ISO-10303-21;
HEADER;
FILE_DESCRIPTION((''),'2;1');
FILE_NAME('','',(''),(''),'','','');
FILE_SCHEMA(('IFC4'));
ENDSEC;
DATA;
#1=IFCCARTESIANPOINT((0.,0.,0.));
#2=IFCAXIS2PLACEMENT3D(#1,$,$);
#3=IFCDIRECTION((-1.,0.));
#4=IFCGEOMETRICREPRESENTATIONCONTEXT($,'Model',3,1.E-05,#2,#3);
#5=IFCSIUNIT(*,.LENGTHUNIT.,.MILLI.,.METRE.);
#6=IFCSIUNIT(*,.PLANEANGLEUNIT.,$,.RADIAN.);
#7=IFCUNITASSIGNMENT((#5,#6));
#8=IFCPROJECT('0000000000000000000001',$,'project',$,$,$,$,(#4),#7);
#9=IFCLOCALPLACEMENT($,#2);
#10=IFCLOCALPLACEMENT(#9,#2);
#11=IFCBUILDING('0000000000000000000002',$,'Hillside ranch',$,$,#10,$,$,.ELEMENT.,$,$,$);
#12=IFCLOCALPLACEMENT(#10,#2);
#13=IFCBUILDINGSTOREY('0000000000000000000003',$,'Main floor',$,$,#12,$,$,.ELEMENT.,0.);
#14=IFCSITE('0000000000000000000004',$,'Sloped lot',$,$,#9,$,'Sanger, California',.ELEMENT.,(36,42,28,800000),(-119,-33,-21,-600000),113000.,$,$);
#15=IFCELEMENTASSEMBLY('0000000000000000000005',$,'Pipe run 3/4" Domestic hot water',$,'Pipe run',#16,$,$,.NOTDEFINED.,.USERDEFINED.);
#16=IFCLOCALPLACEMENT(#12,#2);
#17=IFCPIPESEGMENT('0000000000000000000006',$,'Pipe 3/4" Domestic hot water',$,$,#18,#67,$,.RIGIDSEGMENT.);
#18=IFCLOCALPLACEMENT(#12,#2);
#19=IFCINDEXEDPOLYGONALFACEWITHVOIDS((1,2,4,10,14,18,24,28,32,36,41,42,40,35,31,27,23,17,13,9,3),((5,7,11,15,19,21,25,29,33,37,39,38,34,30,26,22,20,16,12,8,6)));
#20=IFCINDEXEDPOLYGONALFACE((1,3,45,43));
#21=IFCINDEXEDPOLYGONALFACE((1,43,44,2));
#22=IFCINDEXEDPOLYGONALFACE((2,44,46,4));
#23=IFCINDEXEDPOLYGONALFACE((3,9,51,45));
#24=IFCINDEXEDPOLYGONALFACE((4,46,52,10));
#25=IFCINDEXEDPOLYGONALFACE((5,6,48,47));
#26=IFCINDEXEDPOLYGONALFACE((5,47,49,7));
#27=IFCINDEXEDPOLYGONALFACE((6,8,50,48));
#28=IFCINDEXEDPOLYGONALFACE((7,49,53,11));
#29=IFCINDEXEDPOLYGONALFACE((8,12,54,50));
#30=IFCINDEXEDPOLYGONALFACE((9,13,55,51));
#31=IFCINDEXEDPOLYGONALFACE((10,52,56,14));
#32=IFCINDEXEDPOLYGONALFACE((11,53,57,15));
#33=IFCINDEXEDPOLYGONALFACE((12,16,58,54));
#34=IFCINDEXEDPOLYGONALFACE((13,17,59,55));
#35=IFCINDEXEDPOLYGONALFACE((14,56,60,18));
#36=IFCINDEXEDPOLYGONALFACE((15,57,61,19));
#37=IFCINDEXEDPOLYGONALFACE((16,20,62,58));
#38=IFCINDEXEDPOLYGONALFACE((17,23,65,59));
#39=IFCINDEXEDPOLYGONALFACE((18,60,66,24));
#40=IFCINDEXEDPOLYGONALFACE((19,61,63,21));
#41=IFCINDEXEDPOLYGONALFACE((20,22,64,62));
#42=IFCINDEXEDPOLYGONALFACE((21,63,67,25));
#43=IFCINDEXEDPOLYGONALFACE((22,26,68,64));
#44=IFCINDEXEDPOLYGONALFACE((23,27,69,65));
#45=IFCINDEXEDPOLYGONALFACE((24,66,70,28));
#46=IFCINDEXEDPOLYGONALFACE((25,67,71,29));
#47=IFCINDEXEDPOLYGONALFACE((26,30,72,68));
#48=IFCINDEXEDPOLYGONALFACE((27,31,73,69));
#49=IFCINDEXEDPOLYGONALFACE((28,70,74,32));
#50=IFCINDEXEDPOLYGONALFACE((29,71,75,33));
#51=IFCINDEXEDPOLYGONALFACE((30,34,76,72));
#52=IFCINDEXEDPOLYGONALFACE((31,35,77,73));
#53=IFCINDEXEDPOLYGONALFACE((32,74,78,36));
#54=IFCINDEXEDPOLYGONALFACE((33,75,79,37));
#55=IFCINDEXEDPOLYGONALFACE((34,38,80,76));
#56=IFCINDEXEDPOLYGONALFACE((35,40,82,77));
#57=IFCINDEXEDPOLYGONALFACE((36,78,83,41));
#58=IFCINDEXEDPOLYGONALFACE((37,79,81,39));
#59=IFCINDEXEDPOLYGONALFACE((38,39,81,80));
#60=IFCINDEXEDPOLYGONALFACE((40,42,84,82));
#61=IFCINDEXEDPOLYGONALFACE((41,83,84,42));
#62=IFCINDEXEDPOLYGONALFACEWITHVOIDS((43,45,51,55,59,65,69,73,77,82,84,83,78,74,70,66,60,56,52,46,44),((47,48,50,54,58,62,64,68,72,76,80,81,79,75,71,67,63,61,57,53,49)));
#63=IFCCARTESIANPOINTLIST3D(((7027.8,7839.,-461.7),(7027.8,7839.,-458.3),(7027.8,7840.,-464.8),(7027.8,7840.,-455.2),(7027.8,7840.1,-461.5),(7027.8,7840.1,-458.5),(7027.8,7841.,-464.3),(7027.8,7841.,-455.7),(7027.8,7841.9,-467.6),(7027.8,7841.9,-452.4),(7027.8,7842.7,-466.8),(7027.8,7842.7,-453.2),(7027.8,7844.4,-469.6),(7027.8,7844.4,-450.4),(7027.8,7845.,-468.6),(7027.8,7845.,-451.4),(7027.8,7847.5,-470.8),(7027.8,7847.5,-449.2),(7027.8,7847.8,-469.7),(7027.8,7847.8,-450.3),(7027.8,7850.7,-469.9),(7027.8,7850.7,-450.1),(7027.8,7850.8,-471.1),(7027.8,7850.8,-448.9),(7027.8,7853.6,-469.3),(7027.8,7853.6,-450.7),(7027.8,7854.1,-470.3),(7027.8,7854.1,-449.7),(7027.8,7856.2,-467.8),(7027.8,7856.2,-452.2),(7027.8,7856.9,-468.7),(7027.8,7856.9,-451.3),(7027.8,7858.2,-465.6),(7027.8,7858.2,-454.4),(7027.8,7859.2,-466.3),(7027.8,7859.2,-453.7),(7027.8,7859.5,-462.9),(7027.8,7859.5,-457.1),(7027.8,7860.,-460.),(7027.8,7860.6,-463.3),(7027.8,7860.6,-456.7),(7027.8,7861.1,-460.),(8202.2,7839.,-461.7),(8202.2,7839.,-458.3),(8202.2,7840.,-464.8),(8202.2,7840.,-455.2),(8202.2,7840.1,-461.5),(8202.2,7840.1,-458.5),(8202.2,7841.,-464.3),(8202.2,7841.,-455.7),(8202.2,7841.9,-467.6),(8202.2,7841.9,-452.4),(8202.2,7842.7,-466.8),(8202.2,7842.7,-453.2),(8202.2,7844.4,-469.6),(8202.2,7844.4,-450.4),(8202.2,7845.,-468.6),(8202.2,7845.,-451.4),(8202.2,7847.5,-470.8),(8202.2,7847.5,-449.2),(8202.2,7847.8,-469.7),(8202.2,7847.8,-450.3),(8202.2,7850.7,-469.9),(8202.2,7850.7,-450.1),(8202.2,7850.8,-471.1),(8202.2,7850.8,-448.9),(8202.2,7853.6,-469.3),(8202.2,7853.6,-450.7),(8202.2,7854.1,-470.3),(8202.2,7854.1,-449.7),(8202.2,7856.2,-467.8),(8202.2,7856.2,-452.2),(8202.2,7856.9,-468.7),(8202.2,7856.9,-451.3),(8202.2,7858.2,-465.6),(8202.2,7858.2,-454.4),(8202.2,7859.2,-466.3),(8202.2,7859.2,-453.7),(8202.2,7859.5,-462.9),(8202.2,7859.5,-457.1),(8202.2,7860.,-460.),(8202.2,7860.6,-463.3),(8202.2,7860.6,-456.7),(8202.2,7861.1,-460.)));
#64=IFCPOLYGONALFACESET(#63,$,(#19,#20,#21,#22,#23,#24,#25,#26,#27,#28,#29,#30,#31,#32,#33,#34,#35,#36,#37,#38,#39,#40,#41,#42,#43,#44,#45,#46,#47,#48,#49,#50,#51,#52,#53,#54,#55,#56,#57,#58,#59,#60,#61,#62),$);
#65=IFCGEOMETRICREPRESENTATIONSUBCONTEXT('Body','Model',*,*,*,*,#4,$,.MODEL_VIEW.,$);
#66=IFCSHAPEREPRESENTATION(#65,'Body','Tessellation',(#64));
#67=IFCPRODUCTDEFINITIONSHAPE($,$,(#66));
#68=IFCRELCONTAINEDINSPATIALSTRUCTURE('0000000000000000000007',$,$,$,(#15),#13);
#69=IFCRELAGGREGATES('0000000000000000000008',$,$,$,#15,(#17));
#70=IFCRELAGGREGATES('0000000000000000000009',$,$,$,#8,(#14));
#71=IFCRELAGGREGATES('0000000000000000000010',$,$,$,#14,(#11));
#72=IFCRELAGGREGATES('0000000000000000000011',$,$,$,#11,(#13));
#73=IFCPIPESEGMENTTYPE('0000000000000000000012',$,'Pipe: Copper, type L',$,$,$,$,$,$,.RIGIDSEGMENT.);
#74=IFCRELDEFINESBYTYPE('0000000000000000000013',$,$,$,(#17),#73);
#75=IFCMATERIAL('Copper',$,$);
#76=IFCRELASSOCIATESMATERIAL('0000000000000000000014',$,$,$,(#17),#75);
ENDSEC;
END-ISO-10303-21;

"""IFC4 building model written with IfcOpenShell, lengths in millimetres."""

from ifc_helpers import new_model, si_unit, direction, frame, origin, origin_with_axes, origin_2d, place, context, subcontext, project, spatial, hollow_circle, extrude, material, type_object, element, aggregate, save


model = new_model("IFC4")

# Units and contexts
model_context = context("Model", 3, precision=1e-05, world=origin(), true_north=direction((-1.0, 0.0)))
body_context = subcontext(model_context, "Body", "Model", "MODEL_VIEW")
ifc_project = project(units=[si_unit("LENGTHUNIT", "METRE", prefix="MILLI"), si_unit("PLANEANGLEUNIT", "RADIAN")], contexts=[model_context])

# Site, building, storey
site_placement = place(None, origin())
site = spatial("IfcSite", under=ifc_project, at=site_placement, Name="Sloped lot", LongName="Sanger, California", CompositionType="ELEMENT", RefLatitude=(36, 42, 28, 800000), RefLongitude=(-119, -33, -21, -600000), RefElevation=113000.0)
building_placement = place(site_placement, origin())
building = spatial("IfcBuilding", under=site, at=building_placement, Name="Hillside ranch", CompositionType="ELEMENT")
storey_placement = place(building_placement, origin())
storey = spatial("IfcBuildingStorey", under=building, at=storey_placement, Name="Main floor", CompositionType="ELEMENT", Elevation=0.0)

# Element assembly
ifc_material = material(Name="Copper")
assembly_1_placement = place(storey_placement, origin_with_axes())
assembly_1 = element("IfcElementAssembly", 1, at=assembly_1_placement, inside=storey, Name="Pipe run 3/4\" Domestic hot water", ObjectType="Pipe run", AssemblyPlace="NOTDEFINED", PredefinedType="USERDEFINED")

# Pipe segment
pipe_segment_type = type_object("IfcPipeSegmentType", Name="Pipe: Copper, type L", PredefinedType="RIGIDSEGMENT")
pipe_segment_1_placement = place(storey_placement, origin_with_axes())
pipe_segment_1 = element("IfcPipeSegment", 2, at=pipe_segment_1_placement, type_object=pipe_segment_type, material=ifc_material, Name="Pipe 3/4\" Domestic hot water", PredefinedType="RIGIDSEGMENT", context=body_context, shape_type="SweptSolid", body=[
    extrude(hollow_circle(Radius=11.1, WallThickness=1.1, at=origin_2d()), frame((7027.8, 7850.0, -460.0), z_axis=(1.0, 0.0, 0.0), x_axis=(0.0, 1.0, 0.0)), (0.0, 0.0, 1.0), 1174.5),
])
aggregate(assembly_1, [pipe_segment_1])

save(model, "model.ifc")
